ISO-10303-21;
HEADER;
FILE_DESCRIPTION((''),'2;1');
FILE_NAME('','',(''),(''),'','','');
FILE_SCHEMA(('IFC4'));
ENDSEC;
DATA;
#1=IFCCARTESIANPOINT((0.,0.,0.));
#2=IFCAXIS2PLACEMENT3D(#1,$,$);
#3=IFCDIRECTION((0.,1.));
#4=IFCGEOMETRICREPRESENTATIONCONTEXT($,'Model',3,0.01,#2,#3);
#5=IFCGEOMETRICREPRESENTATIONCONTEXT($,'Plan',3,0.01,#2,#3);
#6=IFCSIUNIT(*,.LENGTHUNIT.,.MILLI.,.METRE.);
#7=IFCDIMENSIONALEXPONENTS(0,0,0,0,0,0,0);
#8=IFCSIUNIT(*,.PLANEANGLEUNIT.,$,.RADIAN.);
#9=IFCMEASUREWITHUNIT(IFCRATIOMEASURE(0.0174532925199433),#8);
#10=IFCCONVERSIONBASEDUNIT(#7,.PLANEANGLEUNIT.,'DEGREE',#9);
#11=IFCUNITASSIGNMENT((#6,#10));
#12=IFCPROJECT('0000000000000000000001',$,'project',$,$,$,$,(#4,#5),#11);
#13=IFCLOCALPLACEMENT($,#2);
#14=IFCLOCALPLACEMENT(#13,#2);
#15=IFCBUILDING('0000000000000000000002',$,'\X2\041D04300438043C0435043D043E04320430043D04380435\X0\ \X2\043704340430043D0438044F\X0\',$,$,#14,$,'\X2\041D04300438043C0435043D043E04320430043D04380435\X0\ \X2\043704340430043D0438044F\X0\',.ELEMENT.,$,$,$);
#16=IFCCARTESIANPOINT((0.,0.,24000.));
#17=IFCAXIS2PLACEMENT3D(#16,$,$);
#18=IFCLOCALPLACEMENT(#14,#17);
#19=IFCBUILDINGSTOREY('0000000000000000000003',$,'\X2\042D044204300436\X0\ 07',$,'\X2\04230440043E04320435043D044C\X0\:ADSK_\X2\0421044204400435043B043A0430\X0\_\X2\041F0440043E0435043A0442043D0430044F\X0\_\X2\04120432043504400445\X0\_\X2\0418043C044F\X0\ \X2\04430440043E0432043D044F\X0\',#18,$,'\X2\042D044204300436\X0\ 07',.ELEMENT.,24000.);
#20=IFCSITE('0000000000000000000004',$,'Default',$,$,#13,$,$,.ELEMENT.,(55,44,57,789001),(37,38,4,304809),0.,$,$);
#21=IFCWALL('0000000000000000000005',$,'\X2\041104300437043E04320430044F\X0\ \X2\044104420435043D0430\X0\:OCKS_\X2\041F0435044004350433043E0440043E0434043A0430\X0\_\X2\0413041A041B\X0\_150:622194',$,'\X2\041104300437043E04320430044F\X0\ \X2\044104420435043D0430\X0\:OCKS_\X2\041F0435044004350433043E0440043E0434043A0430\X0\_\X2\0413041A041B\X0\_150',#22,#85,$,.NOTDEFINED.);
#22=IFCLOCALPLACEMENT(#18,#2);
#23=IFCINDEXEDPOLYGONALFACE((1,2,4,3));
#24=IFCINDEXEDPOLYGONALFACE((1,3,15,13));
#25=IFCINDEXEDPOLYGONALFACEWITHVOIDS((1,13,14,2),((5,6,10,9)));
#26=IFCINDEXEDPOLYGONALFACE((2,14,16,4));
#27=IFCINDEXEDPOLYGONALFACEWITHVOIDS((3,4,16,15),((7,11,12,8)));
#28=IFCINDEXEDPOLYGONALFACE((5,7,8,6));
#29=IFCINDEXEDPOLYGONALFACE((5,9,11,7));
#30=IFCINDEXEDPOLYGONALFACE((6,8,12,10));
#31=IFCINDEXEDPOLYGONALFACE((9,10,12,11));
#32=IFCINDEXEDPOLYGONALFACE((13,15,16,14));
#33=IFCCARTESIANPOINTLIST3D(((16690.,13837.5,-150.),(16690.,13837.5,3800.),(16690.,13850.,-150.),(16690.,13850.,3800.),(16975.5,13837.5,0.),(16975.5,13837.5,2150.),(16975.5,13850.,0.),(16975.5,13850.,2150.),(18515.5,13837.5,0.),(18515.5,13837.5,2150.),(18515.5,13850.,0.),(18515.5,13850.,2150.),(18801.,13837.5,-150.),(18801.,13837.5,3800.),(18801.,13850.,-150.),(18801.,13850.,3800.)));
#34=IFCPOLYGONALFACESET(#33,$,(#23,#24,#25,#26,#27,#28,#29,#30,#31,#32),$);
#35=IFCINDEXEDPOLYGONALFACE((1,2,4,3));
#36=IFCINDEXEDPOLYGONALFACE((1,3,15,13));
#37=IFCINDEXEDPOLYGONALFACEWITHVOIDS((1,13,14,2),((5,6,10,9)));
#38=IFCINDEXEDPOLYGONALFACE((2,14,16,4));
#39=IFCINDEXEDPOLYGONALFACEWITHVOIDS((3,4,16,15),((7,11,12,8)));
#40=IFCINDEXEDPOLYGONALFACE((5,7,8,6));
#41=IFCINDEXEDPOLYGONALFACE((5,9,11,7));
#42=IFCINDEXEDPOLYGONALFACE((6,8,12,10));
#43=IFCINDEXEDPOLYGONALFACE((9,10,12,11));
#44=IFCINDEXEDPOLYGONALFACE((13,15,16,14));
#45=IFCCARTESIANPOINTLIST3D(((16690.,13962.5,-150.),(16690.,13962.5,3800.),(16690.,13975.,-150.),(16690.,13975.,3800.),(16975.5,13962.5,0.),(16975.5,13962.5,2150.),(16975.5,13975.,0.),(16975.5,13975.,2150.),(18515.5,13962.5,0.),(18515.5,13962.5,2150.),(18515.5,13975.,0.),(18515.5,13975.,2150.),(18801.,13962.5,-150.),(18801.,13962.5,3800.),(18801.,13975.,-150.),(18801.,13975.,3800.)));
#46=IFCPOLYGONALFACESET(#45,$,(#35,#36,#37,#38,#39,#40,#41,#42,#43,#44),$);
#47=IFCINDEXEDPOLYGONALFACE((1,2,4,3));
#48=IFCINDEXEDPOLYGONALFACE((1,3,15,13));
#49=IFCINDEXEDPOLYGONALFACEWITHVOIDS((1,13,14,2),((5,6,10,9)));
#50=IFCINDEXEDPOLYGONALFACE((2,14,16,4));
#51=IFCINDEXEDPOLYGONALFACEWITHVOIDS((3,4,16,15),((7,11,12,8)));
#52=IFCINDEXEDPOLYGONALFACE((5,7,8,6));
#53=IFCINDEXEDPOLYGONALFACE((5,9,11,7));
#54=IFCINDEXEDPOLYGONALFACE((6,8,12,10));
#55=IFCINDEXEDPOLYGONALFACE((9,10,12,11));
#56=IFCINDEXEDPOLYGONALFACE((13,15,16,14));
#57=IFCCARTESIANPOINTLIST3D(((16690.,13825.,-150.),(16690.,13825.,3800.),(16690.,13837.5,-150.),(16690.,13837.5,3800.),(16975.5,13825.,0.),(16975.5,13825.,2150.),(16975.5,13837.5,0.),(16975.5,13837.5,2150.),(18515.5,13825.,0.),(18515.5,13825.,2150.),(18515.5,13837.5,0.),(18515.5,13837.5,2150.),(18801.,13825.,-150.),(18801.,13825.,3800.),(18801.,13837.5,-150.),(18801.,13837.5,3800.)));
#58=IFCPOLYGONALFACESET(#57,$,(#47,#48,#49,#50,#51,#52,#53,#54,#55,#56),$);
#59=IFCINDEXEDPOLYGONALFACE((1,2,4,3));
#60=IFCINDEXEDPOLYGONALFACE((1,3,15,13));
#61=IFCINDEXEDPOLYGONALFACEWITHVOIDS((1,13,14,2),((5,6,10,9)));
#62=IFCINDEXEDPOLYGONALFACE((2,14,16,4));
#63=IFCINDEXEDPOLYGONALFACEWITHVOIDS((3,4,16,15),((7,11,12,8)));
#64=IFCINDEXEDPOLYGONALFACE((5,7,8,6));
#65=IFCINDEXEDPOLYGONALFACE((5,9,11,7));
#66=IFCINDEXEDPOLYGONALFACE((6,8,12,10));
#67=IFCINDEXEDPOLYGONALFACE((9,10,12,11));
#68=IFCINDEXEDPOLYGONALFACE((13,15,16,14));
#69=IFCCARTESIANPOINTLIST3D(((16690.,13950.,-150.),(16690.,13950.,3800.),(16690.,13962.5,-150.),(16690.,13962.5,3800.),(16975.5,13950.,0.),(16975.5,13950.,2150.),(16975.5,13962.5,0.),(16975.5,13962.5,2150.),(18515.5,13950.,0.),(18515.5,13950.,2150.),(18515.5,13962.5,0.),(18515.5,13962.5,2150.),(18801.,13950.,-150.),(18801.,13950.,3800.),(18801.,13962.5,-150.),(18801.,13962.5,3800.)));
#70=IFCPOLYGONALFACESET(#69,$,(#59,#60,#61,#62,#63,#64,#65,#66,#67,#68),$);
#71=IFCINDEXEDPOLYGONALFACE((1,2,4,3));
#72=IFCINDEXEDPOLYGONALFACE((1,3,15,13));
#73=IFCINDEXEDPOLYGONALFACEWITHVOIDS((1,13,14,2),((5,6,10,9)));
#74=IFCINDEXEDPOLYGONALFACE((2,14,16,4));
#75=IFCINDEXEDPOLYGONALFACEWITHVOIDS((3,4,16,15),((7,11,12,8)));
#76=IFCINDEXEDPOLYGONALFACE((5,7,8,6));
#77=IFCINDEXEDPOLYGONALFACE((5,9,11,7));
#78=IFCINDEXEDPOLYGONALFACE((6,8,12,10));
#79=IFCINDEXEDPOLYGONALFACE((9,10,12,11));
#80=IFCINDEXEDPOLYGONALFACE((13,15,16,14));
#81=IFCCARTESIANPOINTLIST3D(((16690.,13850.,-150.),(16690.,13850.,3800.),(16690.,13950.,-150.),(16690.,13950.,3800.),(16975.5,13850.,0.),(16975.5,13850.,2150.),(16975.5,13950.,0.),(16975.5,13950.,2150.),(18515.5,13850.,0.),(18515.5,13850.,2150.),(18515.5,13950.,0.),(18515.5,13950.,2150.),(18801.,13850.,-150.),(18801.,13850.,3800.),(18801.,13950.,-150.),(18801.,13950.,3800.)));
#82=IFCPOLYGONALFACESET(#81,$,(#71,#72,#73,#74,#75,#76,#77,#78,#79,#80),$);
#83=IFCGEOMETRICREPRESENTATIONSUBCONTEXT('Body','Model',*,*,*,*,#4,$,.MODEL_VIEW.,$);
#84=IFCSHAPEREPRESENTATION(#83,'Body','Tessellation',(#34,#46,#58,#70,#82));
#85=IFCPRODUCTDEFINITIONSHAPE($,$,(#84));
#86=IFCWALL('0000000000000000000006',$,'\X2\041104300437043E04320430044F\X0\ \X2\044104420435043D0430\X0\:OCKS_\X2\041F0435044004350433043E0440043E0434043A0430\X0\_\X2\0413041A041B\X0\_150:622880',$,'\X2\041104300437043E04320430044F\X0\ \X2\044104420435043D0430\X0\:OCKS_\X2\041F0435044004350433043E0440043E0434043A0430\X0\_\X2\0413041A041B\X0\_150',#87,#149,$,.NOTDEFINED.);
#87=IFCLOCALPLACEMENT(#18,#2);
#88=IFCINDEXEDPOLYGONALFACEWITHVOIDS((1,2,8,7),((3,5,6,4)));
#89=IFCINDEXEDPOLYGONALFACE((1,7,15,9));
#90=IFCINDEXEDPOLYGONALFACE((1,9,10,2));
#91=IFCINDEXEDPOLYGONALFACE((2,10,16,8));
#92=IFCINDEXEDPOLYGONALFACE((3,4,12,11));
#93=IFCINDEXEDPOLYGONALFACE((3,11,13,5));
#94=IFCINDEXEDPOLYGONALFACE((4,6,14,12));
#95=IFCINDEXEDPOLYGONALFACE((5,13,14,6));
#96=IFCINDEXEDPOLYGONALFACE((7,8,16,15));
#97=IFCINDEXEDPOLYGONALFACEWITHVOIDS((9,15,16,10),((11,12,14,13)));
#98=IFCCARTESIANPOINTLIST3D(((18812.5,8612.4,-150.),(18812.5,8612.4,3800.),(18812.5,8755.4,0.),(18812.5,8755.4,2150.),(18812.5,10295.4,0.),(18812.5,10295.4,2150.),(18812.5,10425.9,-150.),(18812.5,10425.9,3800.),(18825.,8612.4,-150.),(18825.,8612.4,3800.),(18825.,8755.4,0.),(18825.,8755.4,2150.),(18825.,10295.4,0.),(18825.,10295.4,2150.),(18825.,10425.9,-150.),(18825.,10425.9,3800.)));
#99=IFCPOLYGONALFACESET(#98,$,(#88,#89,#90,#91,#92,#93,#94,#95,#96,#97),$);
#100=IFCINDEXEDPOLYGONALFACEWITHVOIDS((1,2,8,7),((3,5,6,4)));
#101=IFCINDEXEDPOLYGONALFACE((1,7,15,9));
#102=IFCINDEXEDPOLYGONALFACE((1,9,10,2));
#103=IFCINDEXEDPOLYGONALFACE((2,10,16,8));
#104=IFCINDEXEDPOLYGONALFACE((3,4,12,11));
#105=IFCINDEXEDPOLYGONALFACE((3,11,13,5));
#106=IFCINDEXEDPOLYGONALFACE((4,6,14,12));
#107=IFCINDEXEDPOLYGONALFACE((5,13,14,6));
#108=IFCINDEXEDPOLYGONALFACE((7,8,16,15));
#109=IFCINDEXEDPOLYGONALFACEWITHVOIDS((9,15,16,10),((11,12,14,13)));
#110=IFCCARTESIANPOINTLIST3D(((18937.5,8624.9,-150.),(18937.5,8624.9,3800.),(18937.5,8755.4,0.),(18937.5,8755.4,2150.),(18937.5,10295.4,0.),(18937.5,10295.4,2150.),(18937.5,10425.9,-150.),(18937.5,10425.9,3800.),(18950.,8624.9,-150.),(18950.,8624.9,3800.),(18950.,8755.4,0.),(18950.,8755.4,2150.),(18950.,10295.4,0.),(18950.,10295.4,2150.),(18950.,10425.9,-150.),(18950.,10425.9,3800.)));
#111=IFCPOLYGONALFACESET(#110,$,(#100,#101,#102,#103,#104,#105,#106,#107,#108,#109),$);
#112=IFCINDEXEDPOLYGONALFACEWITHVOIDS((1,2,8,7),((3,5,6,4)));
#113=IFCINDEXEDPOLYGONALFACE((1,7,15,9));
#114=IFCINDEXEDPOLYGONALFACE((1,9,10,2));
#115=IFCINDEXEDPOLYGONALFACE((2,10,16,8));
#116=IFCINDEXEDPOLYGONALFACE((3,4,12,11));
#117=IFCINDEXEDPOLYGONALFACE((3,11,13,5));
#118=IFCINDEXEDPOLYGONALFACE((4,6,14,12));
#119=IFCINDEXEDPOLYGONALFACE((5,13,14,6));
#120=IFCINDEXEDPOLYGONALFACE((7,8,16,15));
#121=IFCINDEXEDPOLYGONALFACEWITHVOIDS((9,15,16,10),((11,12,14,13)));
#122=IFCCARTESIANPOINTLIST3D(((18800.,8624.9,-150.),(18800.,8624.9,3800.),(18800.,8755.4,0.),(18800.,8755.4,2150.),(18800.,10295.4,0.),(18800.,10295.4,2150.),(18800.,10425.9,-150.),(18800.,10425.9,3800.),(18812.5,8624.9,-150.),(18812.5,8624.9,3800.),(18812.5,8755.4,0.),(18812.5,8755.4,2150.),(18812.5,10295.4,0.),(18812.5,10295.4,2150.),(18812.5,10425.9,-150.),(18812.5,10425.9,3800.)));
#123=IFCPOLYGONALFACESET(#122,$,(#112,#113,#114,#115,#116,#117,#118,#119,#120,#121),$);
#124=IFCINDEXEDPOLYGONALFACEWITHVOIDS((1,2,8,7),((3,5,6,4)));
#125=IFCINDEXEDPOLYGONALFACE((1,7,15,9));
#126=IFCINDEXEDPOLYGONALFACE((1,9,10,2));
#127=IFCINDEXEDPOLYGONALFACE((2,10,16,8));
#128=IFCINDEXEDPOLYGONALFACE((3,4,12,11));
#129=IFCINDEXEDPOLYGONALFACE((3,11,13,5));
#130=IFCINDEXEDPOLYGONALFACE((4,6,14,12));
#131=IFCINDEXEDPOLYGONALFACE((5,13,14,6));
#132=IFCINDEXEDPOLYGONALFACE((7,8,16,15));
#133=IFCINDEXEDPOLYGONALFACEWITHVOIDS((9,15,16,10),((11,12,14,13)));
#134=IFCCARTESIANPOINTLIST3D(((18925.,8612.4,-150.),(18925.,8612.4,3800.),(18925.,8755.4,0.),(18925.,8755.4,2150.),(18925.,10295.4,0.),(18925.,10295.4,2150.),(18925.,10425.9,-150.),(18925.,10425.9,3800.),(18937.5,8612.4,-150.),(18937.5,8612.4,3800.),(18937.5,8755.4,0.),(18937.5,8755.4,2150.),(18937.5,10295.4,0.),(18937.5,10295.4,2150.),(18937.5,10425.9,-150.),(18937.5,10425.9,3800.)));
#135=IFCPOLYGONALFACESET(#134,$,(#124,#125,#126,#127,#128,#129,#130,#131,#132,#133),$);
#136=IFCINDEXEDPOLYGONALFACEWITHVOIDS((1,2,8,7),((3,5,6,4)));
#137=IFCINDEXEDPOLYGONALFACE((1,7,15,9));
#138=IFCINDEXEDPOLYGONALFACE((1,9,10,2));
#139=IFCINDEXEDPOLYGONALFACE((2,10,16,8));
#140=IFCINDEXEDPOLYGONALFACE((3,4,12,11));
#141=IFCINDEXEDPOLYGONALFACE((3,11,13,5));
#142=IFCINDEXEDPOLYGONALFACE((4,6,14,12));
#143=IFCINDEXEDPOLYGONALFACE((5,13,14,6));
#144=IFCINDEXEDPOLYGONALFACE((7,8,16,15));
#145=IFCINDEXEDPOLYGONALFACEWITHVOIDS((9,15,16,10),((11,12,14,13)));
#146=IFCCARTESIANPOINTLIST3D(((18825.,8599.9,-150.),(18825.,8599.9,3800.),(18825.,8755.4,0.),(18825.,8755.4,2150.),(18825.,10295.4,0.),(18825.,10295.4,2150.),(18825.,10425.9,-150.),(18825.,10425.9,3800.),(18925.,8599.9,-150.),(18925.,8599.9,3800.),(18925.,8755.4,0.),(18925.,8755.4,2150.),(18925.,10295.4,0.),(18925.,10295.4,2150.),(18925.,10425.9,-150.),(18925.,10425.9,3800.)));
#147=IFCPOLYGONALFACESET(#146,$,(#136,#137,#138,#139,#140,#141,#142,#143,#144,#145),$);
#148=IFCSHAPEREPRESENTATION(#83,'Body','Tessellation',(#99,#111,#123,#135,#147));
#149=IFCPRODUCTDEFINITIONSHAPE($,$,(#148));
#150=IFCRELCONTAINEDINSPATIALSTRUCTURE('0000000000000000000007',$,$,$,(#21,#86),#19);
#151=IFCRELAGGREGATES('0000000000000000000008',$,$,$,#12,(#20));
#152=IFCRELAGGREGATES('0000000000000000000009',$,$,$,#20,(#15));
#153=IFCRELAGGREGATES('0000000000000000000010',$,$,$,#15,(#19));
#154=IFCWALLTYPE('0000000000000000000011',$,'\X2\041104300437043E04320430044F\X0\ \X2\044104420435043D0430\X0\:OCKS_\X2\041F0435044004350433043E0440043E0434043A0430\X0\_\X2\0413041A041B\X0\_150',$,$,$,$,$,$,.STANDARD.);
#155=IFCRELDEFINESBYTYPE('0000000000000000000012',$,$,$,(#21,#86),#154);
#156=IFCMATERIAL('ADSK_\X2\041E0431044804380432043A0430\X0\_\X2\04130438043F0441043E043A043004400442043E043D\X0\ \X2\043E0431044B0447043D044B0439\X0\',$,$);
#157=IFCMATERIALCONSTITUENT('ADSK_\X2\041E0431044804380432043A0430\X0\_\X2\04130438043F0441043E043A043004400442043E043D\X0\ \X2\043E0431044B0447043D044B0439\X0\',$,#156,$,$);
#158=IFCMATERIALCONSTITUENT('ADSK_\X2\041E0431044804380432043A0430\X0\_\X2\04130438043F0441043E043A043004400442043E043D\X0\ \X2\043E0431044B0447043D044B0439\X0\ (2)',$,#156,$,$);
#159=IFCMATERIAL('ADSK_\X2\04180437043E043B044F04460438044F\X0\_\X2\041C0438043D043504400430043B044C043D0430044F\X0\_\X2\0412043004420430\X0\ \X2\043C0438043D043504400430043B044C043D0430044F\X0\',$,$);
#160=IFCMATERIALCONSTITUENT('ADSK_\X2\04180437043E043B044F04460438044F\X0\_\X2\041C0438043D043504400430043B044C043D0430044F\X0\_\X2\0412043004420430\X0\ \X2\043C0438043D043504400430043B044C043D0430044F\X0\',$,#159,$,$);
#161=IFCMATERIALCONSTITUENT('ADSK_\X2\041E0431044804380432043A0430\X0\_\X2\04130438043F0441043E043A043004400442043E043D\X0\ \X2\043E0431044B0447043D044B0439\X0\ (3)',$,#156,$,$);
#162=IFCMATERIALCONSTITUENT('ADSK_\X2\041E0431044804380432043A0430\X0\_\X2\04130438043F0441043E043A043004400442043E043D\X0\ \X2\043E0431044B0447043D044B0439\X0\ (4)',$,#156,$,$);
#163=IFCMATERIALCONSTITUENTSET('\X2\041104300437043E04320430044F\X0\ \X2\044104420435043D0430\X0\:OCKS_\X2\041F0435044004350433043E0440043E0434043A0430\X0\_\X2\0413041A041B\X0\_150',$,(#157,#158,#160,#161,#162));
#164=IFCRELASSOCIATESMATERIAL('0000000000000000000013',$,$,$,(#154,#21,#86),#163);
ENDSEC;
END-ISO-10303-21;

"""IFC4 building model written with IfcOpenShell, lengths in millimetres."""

from ifc_helpers import new_model, entity, si_unit, converted_unit, direction, frame, origin, place, context, subcontext, project, spatial, indexed_curve, outline, extrude, material, constituent, constituent_set, type_object, element, save


model = new_model("IFC4")

# Units and contexts
model_context = context("Model", 3, precision=0.01, world=origin(), true_north=direction((0.0, 1.0)))
plan_context = context("Plan", 3, precision=0.01, world=origin(), true_north=direction((0.0, 1.0)))
body_context = subcontext(model_context, "Body", "Model", "MODEL_VIEW")
ifc_project = project(units=[si_unit("LENGTHUNIT", "METRE", prefix="MILLI"), converted_unit("PLANEANGLEUNIT", "DEGREE", entity("IfcRatioMeasure", 0.0174532925199433), si_unit("PLANEANGLEUNIT", "RADIAN"), dimensions=[0, 0, 0, 0, 0, 0, 0])], contexts=[model_context, plan_context])

# Site, building, storey
site_placement = place(None, frame((0.0, 0.0, 0.0)))
site = spatial("IfcSite", under=ifc_project, at=site_placement, Name="Default", CompositionType="ELEMENT", RefLatitude=(55, 44, 57, 789001), RefLongitude=(37, 38, 4, 304809), RefElevation=0.0)
building_placement = place(site_placement, origin())
building = spatial("IfcBuilding", under=site, at=building_placement, Name="Наименование здания", LongName="Наименование здания", CompositionType="ELEMENT")
storey_placement = place(building_placement, frame((0.0, 0.0, 24000.0)))
storey = spatial("IfcBuildingStorey", under=building, at=storey_placement, Name="Этаж 07", ObjectType="Уровень:ADSK_Стрелка_Проектная_Вверх_Имя уровня", LongName="Этаж 07", CompositionType="ELEMENT", Elevation=24000.0)

# Walls, openings
ifc_material_1 = material(Name="ADSK_Обшивка_Гипсокартон обычный")
ifc_constituent_1 = constituent(ifc_material_1, Name="ADSK_Обшивка_Гипсокартон обычный")
ifc_constituent_2 = constituent(ifc_material_1, Name="ADSK_Обшивка_Гипсокартон обычный (2)")
ifc_material_2 = material(Name="ADSK_Изоляция_Минеральная_Вата минеральная")
ifc_constituent_3 = constituent(ifc_material_2, Name="ADSK_Изоляция_Минеральная_Вата минеральная")
ifc_constituent_4 = constituent(ifc_material_1, Name="ADSK_Обшивка_Гипсокартон обычный (3)")
ifc_constituent_5 = constituent(ifc_material_1, Name="ADSK_Обшивка_Гипсокартон обычный (4)")
ifc_constituent_set_1 = constituent_set(constituents=[ifc_constituent_1, ifc_constituent_2, ifc_constituent_3, ifc_constituent_4, ifc_constituent_5], Name="Базовая стена:OCKS_Перегородка_ГКЛ_150")
wall_type_1 = type_object("IfcWallType", Name="Базовая стена:OCKS_Перегородка_ГКЛ_150", PredefinedType="STANDARD", material=ifc_constituent_set_1)
wall_1_placement = place(storey_placement, frame((18801.0, 13900.0, -150.0), z_axis=(0.0, 0.0, 1.0), x_axis=(-1.0, 0.0, 0.0)))
wall_1 = element("IfcWall", 1, at=wall_1_placement, inside=storey, type_object=wall_type_1, material=ifc_constituent_set_1, Name="Базовая стена:OCKS_Перегородка_ГКЛ_150:622194", ObjectType="Базовая стена:OCKS_Перегородка_ГКЛ_150", PredefinedType="NOTDEFINED", context=body_context, shape_type="SweptSolid", body=[
    extrude(outline(indexed_curve([(-1975.0, -1055.5), (1975.0, -1055.5), (1975.0, 1055.5), (-1975.0, 1055.5), (-1975.0, -1055.5)], self_intersect=False), holes=[indexed_curve([(-1825.0, -770.0), (-1825.0, 770.0), (325.0, 770.0), (325.0, -770.0), (-1825.0, -770.0)], self_intersect=False)]), frame((1055.5, 62.5, 1975.0), z_axis=(0.0, -1.0, 0.0), x_axis=(0.0, 0.0, 1.0)), (0.0, 0.0, 1.0), 12.5),
    extrude(outline(indexed_curve([(-1975.0, -1055.5), (1975.0, -1055.5), (1975.0, 1055.5), (-1975.0, 1055.5), (-1975.0, -1055.5)], self_intersect=False), holes=[indexed_curve([(-1825.0, -770.0), (-1825.0, 770.0), (325.0, 770.0), (325.0, -770.0), (-1825.0, -770.0)], self_intersect=False)]), frame((1055.5, -62.5, 1975.0), z_axis=(0.0, -1.0, 0.0), x_axis=(0.0, 0.0, 1.0)), (0.0, 0.0, 1.0), 12.5),
    extrude(outline(indexed_curve([(-1975.0, -704.0), (1975.0, -704.0), (1975.0, -703.0), (1975.0, 1407.0), (-1975.0, 1407.0), (-1975.0, -703.0), (-1975.0, -704.0)], self_intersect=False), holes=[indexed_curve([(-1825.0, -418.5), (-1825.0, 1121.5), (325.0, 1121.5), (325.0, -418.5), (-1825.0, -418.5)], self_intersect=False)]), frame((1407.0, 75.0, 1975.0), z_axis=(0.0, -1.0, 0.0), x_axis=(0.0, 0.0, 1.0)), (0.0, 0.0, 1.0), 12.5),
    extrude(outline(indexed_curve([(-1975.0, -1055.5), (1975.0, -1055.5), (1975.0, 1055.5), (-1975.0, 1055.5), (-1975.0, -1055.5)], self_intersect=False), holes=[indexed_curve([(-1825.0, -770.0), (-1825.0, 770.0), (325.0, 770.0), (325.0, -770.0), (-1825.0, -770.0)], self_intersect=False)]), frame((1055.5, -50.0, 1975.0), z_axis=(0.0, -1.0, 0.0), x_axis=(0.0, 0.0, 1.0)), (0.0, 0.0, 1.0), 12.5),
    extrude(outline(indexed_curve([(-1975.0, -1055.5), (1975.0, -1055.5), (1975.0, 1055.5), (-1975.0, 1055.5), (-1975.0, -1055.5)], self_intersect=False), holes=[indexed_curve([(-1825.0, -770.0), (-1825.0, 770.0), (325.0, 770.0), (325.0, -770.0), (-1825.0, -770.0)], self_intersect=False)]), frame((1055.5, 50.0, 1975.0), z_axis=(0.0, -1.0, 0.0), x_axis=(0.0, 0.0, 1.0)), (0.0, 0.0, 1.0), 100.0),
])
opening_1_placement = place(wall_1_placement, frame((18801.0, 13900.0, 150.0), z_axis=(0.0, 0.0, 1.0), x_axis=(-1.0, 0.0, 0.0)))
element("IfcOpeningElement", 2, at=opening_1_placement, cuts=wall_1, PredefinedType="OPENING", context=body_context, shape_type="SweptSolid", body=[
    extrude(outline(indexed_curve([(-1075.0, -770.0), (1075.0, -770.0), (1075.0, 770.0), (-1075.0, 770.0), (-1075.0, -770.0)], self_intersect=False)), frame((17745.5, 14575.0, 1075.0), z_axis=(0.0, -1.0, 0.0), x_axis=(0.0, 0.0, -1.0)), (0.0, 0.0, 1.0), 1350.0),
])
wall_2_placement = place(storey_placement, frame((18875.0, 8624.9, -150.0), z_axis=(0.0, 0.0, 1.0), x_axis=(0.0, 1.0, 0.0)))
wall_2 = element("IfcWall", 3, at=wall_2_placement, inside=storey, type_object=wall_type_1, material=ifc_constituent_set_1, Name="Базовая стена:OCKS_Перегородка_ГКЛ_150:622880", ObjectType="Базовая стена:OCKS_Перегородка_ГКЛ_150", PredefinedType="NOTDEFINED", context=body_context, shape_type="SweptSolid", body=[
    extrude(outline(indexed_curve([(-1975.0, -906.8), (1975.0, -906.8), (1975.0, 906.8), (-1975.0, 906.8), (-1975.0, -906.8)], self_intersect=False), holes=[indexed_curve([(-1825.0, -776.3), (-1825.0, 763.7), (325.0, 763.8), (325.0, -776.3), (-1825.0, -776.3)], self_intersect=False)]), frame((894.3, 62.5, 1975.0), z_axis=(0.0, -1.0, 0.0), x_axis=(0.0, 0.0, 1.0)), (0.0, 0.0, 1.0), 12.5),
    extrude(outline(indexed_curve([(-1975.0, -900.5), (1975.0, -900.5), (1975.0, 900.5), (-1975.0, 900.5), (-1975.0, -900.5)], self_intersect=False), holes=[indexed_curve([(-1825.0, -770.0), (-1825.0, 770.0), (325.0, 770.0), (325.0, -770.0), (-1825.0, -770.0)], self_intersect=False)]), frame((900.5, -62.5, 1975.0), z_axis=(0.0, -1.0, 0.0), x_axis=(0.0, 0.0, 1.0)), (0.0, 0.0, 1.0), 12.5),
    extrude(outline(indexed_curve([(-1975.0, -900.5), (1975.0, -900.5), (1975.0, 900.5), (-1975.0, 900.5), (-1975.0, -900.5)], self_intersect=False), holes=[indexed_curve([(-1825.0, -770.0), (-1825.0, 770.0), (325.0, 770.0), (325.0, -770.0), (-1825.0, -770.0)], self_intersect=False)]), frame((900.5, 75.0, 1975.0), z_axis=(0.0, -1.0, 0.0), x_axis=(0.0, 0.0, 1.0)), (0.0, 0.0, 1.0), 12.5),
    extrude(outline(indexed_curve([(-1975.0, -906.8), (1975.0, -906.8), (1975.0, 906.8), (-1975.0, 906.8), (-1975.0, -906.8)], self_intersect=False), holes=[indexed_curve([(-1825.0, -776.3), (-1825.0, 763.7), (325.0, 763.7), (325.0, -776.3), (-1825.0, -776.3)], self_intersect=False)]), frame((894.3, -50.0, 1975.0), z_axis=(0.0, -1.0, 0.0), x_axis=(0.0, 0.0, 1.0)), (0.0, 0.0, 1.0), 12.5),
    extrude(outline(indexed_curve([(-1975.0, -913.0), (1975.0, -913.0), (1975.0, 913.0), (-1975.0, 913.0), (-1975.0, -913.0)], self_intersect=False), holes=[indexed_curve([(-1825.0, -782.5), (-1825.0, 757.5), (325.0, 757.5), (325.0, -782.5), (-1825.0, -782.5)], self_intersect=False)]), frame((888.0, 50.0, 1975.0), z_axis=(0.0, -1.0, 0.0), x_axis=(0.0, 0.0, 1.0)), (0.0, 0.0, 1.0), 100.0),
])
opening_2_placement = place(wall_2_placement, frame((-8624.9, 18875.0, 150.0), z_axis=(0.0, 0.0, 1.0), x_axis=(0.0, -1.0, 0.0)))
element("IfcOpeningElement", 4, at=opening_2_placement, cuts=wall_2, PredefinedType="OPENING", context=body_context, shape_type="SweptSolid", body=[
    extrude(outline(indexed_curve([(-1075.0, -770.0), (1075.0, -770.0), (1075.0, 770.0), (-1075.0, 770.0), (-1075.0, -770.0)], self_intersect=False)), frame((19550.0, 9525.4, 1075.0), z_axis=(-1.0, 0.0, 0.0), x_axis=(0.0, 0.0, -1.0)), (0.0, 0.0, 1.0), 1350.0),
])

save(model, "model.ifc")
